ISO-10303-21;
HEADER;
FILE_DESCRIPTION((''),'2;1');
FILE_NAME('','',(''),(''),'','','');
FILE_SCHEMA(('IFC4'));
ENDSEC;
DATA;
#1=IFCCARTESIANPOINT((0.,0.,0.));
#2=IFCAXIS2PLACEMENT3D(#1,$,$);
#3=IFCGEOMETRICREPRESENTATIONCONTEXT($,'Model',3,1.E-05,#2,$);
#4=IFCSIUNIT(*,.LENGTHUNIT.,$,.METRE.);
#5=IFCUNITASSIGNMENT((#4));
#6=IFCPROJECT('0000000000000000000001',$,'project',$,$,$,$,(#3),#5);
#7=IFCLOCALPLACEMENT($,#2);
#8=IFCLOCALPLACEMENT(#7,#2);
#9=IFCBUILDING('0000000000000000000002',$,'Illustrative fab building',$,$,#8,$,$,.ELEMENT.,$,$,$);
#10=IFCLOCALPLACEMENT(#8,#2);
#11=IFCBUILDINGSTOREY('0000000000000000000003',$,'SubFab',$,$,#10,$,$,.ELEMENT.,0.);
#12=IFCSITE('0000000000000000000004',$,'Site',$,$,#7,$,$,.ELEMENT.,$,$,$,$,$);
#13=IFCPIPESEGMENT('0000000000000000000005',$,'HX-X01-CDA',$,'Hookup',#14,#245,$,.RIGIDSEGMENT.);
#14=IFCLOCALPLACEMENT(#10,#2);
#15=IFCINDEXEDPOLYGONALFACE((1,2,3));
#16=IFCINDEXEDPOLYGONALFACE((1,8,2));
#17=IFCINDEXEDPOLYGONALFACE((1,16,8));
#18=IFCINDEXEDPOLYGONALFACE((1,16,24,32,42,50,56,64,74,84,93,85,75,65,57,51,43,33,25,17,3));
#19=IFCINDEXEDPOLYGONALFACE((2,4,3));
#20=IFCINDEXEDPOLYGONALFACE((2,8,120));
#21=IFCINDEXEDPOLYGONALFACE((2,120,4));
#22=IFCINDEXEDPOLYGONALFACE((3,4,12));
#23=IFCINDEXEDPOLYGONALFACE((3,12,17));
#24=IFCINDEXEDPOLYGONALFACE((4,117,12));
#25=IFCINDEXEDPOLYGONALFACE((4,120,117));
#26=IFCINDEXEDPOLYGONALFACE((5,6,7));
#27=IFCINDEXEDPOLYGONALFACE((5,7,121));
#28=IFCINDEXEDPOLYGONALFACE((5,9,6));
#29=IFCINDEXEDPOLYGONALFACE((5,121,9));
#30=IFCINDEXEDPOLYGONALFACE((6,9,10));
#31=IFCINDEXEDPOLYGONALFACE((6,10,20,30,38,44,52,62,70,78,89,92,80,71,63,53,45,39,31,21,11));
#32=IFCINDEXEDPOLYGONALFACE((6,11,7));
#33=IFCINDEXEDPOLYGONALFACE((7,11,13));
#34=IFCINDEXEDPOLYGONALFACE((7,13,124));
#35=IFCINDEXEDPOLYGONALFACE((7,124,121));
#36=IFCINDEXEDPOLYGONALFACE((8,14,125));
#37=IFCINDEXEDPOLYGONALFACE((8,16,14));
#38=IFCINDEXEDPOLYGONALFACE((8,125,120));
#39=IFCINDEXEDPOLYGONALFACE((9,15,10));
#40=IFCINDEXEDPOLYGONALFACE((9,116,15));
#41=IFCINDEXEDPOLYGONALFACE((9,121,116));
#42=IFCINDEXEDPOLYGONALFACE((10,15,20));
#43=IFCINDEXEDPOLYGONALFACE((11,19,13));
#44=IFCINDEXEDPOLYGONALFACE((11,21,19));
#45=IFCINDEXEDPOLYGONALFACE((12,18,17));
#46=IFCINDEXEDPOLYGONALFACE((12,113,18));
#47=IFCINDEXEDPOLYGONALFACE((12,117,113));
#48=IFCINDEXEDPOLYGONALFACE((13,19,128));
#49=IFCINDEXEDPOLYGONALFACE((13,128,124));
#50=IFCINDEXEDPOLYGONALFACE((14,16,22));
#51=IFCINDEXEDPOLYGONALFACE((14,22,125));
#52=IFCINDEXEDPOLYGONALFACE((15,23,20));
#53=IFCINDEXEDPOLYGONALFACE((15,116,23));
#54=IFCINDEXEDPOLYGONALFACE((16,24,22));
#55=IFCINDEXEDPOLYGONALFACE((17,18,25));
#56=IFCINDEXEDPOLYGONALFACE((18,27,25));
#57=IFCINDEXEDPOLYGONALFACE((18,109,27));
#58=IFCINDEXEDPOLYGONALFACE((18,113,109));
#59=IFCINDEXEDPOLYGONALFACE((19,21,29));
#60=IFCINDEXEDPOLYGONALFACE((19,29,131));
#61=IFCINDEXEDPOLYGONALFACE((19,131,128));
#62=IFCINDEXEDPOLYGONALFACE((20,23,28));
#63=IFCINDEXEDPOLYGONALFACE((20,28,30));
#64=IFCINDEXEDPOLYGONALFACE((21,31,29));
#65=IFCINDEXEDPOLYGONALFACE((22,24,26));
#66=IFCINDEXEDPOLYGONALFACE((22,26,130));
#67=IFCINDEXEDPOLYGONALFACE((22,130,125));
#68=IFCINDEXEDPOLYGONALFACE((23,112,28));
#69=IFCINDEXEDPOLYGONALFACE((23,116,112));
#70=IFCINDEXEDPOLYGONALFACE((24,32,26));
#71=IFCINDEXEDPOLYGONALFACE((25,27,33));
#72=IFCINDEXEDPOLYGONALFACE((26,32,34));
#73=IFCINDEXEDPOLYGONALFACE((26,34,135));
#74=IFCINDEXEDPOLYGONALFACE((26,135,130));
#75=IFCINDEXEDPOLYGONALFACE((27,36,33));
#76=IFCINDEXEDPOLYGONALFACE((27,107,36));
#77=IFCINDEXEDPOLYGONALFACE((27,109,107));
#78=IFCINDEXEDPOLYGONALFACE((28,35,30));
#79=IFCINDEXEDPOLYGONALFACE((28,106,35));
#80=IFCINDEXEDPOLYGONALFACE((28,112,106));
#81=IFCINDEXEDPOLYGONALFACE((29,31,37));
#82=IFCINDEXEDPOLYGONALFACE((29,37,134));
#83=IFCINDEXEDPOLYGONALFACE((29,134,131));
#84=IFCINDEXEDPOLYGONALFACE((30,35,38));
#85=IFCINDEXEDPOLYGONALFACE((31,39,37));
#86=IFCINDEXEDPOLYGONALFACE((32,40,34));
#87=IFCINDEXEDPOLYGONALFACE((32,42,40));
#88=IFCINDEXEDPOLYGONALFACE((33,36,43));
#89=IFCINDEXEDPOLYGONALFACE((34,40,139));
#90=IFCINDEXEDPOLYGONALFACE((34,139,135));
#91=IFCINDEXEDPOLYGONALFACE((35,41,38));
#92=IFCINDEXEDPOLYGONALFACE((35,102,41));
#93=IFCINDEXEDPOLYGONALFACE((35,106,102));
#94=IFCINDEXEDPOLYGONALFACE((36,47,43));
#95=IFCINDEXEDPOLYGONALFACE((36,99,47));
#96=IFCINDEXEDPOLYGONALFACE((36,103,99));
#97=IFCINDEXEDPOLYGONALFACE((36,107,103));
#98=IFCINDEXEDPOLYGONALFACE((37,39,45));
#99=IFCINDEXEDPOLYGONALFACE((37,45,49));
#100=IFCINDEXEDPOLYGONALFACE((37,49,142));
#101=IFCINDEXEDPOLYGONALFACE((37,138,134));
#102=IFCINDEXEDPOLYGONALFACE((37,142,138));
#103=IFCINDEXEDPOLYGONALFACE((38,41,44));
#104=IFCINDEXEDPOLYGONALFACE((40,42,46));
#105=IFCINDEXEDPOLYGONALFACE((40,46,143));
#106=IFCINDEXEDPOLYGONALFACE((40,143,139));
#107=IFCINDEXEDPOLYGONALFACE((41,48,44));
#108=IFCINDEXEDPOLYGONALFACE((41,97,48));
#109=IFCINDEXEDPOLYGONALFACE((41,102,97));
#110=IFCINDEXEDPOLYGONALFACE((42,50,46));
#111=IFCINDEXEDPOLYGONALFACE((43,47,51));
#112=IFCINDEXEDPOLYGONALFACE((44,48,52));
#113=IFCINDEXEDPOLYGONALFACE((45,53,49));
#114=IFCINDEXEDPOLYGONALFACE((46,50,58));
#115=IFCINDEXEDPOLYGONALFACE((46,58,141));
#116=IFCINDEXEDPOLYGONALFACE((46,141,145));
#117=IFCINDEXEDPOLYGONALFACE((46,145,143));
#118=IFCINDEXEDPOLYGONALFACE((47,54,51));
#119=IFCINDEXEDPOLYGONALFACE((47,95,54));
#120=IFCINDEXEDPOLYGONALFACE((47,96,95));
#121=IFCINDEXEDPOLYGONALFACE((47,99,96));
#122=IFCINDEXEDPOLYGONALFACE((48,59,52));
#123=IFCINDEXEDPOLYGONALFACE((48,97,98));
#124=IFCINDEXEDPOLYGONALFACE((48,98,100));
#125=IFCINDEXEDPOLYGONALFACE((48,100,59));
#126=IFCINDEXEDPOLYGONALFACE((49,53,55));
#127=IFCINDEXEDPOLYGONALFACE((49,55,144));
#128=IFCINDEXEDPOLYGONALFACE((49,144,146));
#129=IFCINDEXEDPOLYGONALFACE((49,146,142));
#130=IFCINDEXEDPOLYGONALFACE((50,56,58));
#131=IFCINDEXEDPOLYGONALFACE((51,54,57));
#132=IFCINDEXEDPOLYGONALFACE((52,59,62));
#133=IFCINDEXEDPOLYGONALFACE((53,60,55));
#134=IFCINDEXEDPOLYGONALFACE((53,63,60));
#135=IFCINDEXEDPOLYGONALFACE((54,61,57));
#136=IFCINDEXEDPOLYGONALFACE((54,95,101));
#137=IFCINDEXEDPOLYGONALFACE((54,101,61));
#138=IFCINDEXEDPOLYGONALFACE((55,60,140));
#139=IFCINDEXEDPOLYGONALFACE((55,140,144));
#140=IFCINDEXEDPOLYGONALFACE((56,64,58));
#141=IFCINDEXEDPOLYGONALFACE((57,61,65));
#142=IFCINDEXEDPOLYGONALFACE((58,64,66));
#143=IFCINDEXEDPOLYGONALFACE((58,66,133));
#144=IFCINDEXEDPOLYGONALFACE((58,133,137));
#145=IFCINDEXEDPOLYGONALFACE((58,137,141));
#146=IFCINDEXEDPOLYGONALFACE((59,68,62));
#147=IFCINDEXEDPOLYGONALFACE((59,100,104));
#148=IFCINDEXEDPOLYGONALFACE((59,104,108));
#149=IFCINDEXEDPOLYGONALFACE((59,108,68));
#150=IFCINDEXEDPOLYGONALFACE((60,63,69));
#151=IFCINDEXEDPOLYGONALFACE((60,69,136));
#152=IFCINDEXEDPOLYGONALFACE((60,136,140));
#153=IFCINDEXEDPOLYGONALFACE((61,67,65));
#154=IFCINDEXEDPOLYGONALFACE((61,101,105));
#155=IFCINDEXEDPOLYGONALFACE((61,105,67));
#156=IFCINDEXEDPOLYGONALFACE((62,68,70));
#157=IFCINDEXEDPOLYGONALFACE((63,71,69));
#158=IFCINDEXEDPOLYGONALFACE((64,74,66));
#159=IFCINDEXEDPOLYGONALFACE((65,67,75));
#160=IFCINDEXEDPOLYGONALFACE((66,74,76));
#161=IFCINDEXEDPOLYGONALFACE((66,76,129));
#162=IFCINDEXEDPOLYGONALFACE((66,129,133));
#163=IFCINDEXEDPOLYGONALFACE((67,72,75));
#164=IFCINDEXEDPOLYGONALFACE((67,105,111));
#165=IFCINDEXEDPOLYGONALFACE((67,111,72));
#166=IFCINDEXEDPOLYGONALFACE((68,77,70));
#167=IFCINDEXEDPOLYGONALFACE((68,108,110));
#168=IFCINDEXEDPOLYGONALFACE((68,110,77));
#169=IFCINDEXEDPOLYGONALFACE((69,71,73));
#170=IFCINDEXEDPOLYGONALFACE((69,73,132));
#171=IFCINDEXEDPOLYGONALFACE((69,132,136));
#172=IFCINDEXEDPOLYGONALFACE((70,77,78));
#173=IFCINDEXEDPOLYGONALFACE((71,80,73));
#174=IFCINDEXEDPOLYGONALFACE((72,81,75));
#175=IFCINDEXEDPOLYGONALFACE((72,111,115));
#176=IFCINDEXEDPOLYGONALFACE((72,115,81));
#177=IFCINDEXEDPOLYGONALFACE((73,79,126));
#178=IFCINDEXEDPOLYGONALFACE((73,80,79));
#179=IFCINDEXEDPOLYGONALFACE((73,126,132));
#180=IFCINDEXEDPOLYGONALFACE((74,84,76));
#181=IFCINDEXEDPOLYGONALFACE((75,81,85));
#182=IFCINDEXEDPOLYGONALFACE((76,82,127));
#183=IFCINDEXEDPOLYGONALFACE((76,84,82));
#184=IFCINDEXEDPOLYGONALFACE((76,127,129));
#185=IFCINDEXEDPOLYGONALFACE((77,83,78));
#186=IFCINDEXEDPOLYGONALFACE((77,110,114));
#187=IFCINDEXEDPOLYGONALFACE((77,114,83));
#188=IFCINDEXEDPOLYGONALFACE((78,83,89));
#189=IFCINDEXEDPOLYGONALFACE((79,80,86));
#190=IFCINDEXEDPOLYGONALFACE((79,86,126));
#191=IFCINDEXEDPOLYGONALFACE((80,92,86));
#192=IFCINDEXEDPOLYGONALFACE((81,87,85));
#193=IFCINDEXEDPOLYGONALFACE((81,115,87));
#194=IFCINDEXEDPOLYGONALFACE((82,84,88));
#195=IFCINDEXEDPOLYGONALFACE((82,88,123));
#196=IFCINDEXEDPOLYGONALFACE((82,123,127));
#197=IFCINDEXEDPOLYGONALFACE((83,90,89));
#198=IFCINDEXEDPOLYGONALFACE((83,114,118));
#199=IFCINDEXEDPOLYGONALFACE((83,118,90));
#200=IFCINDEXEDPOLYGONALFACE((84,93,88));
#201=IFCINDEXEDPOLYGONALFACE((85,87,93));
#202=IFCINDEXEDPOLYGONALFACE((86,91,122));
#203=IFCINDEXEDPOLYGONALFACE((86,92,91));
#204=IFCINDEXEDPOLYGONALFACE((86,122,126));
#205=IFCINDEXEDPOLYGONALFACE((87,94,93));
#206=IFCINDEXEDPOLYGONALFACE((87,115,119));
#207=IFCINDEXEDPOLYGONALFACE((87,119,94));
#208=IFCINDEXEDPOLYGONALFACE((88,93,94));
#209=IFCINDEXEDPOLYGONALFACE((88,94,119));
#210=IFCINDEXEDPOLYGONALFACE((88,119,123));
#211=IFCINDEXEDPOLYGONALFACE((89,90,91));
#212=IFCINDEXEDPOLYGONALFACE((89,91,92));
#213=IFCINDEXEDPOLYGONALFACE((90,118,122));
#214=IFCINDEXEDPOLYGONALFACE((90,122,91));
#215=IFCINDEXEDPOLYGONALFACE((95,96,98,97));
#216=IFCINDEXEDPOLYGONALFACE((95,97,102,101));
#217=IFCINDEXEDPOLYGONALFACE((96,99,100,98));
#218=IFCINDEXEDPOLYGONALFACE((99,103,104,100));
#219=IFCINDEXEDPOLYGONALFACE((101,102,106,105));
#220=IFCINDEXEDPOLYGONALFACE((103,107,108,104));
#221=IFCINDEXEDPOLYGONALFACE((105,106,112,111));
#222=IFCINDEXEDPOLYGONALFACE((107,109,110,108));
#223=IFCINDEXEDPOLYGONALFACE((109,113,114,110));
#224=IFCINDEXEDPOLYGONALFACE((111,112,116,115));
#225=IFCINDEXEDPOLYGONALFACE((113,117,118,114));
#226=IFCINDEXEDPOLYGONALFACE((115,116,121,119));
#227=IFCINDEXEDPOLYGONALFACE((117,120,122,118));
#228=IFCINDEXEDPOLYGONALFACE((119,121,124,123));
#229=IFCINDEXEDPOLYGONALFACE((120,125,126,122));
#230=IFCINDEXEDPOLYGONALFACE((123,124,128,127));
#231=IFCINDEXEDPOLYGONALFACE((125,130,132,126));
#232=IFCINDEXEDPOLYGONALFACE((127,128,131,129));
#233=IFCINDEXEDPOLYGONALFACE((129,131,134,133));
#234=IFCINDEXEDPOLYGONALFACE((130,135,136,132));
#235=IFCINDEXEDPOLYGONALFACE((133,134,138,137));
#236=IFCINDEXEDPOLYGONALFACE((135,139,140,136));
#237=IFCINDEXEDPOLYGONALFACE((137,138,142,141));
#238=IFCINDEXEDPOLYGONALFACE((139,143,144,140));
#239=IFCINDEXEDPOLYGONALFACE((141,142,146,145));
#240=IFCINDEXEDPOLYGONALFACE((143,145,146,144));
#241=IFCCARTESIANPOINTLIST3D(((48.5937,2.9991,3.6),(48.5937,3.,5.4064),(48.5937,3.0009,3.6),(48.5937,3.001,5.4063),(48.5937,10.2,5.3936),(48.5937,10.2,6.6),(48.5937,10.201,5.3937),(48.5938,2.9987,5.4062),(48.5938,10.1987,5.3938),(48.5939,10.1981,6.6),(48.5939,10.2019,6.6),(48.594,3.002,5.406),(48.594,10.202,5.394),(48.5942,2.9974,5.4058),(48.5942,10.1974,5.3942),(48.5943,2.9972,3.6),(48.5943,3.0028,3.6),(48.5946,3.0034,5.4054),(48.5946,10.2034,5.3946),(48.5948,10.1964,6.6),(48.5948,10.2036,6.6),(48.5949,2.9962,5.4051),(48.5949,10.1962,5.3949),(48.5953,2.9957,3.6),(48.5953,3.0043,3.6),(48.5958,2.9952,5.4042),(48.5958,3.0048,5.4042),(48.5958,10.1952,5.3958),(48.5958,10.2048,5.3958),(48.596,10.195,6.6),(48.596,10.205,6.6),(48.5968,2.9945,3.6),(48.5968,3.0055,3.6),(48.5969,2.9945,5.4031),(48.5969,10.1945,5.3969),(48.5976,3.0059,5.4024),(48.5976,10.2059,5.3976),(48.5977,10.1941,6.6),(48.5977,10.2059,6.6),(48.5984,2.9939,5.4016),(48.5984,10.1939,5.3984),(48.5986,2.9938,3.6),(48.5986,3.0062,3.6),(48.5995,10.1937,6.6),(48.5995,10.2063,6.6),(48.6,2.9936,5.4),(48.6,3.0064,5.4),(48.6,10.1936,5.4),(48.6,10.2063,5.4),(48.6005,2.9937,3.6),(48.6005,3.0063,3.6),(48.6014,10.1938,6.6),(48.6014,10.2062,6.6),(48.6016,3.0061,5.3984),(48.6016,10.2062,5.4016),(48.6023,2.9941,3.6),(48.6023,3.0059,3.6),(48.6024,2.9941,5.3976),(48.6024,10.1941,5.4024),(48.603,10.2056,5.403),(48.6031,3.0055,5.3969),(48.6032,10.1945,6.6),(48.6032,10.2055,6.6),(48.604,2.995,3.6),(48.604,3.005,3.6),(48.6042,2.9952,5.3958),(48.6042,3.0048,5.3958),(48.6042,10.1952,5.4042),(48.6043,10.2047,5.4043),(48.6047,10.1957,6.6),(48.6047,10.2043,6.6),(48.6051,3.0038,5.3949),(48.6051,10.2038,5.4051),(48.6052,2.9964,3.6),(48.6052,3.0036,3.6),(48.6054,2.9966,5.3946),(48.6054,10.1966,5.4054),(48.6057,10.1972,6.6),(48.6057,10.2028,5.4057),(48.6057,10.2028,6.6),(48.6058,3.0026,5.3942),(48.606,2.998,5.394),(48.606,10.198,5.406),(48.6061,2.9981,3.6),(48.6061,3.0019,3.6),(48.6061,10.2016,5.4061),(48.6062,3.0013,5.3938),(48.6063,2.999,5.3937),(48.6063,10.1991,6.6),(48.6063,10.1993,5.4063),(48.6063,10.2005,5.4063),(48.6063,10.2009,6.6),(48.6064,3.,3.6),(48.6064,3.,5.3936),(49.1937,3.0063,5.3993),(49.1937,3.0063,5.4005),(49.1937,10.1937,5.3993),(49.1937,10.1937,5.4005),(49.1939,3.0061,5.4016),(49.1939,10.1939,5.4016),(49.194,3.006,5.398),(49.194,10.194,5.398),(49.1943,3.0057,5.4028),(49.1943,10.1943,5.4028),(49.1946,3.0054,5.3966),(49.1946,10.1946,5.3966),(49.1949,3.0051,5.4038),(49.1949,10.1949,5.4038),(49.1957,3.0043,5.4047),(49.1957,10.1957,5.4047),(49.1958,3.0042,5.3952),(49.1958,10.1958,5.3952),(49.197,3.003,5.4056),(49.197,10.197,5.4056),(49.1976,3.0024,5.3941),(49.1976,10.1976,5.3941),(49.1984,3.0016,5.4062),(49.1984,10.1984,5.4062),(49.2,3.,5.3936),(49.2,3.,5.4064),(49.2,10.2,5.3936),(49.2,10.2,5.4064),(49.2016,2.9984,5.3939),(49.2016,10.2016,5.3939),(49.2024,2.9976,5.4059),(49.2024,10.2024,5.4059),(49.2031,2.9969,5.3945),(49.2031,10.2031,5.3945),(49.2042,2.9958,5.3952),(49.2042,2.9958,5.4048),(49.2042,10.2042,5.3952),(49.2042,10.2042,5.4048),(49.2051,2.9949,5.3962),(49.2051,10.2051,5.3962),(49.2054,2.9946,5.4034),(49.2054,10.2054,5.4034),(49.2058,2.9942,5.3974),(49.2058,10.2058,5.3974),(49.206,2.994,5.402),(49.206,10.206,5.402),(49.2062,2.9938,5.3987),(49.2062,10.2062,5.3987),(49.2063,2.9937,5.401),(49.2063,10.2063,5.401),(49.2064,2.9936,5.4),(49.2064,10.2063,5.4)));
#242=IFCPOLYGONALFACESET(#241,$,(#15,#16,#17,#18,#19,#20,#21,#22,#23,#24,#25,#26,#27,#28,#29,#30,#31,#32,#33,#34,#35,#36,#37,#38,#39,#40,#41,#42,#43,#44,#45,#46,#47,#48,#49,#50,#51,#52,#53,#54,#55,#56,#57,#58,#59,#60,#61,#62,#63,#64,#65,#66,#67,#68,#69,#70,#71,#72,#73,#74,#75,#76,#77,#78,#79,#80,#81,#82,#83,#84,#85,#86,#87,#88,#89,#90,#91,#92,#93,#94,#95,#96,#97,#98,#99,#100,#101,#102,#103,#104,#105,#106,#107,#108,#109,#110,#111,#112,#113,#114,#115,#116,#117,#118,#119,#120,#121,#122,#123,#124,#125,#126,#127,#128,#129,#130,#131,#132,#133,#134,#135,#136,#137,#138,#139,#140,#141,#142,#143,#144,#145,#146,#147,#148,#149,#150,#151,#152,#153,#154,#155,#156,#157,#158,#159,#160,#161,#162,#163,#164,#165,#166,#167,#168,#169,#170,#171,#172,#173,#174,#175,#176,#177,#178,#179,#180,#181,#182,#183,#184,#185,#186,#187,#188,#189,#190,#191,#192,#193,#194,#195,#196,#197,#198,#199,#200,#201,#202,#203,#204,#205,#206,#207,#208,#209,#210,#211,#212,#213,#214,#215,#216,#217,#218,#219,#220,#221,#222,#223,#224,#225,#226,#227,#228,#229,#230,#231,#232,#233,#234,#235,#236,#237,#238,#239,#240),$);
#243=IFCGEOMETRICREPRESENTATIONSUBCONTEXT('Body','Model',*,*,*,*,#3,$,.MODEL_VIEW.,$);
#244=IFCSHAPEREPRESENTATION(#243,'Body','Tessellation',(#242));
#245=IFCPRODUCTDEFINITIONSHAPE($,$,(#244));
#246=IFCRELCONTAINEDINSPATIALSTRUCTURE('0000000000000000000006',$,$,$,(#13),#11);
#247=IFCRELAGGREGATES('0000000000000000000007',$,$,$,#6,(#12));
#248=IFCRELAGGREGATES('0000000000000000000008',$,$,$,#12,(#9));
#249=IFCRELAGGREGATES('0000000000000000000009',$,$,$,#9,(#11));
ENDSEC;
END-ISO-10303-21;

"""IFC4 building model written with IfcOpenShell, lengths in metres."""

from ifc_helpers import new_model, entity, si_unit, origin, place, context, subcontext, project, spatial, element, save


model = new_model("IFC4")

# Units and contexts
model_context = context("Model", 3, precision=1e-05, world=origin())
body_context = subcontext(model_context, "Body", "Model", "MODEL_VIEW")
ifc_project = project(units=[si_unit("LENGTHUNIT", "METRE")], contexts=[model_context])

# Site, building, storey
site_placement = place(None, origin())
site = spatial("IfcSite", under=ifc_project, at=site_placement, Name="Site", CompositionType="ELEMENT")
building_placement = place(site_placement, origin())
building = spatial("IfcBuilding", under=site, at=building_placement, Name="Illustrative fab building", CompositionType="ELEMENT")
storey_placement = place(building_placement, origin())
storey = spatial("IfcBuildingStorey", under=building, at=storey_placement, Name="SubFab", CompositionType="ELEMENT", Elevation=0.0)

# Pipe segment
pipe_segment_1_placement = place(storey_placement, origin())
element("IfcPipeSegment", 1, at=pipe_segment_1_placement, inside=storey, Name="HX-X01-CDA", ObjectType="Hookup", PredefinedType="RIGIDSEGMENT", context=body_context, shape_type="AdvancedSweptSolid", body=[
    entity("IfcSweptDiskSolid", entity("IfcPolyline", [entity("IfcCartesianPoint", [48.6, 3.0, 3.6]), entity("IfcCartesianPoint", [48.6, 3.0, 5.4]), entity("IfcCartesianPoint", [49.2, 3.0, 5.4]), entity("IfcCartesianPoint", [49.2, 10.2, 5.4]), entity("IfcCartesianPoint", [48.6, 10.2, 5.4]), entity("IfcCartesianPoint", [48.6, 10.2, 6.6])]), 0.0063),
])

save(model, "model.ifc")
